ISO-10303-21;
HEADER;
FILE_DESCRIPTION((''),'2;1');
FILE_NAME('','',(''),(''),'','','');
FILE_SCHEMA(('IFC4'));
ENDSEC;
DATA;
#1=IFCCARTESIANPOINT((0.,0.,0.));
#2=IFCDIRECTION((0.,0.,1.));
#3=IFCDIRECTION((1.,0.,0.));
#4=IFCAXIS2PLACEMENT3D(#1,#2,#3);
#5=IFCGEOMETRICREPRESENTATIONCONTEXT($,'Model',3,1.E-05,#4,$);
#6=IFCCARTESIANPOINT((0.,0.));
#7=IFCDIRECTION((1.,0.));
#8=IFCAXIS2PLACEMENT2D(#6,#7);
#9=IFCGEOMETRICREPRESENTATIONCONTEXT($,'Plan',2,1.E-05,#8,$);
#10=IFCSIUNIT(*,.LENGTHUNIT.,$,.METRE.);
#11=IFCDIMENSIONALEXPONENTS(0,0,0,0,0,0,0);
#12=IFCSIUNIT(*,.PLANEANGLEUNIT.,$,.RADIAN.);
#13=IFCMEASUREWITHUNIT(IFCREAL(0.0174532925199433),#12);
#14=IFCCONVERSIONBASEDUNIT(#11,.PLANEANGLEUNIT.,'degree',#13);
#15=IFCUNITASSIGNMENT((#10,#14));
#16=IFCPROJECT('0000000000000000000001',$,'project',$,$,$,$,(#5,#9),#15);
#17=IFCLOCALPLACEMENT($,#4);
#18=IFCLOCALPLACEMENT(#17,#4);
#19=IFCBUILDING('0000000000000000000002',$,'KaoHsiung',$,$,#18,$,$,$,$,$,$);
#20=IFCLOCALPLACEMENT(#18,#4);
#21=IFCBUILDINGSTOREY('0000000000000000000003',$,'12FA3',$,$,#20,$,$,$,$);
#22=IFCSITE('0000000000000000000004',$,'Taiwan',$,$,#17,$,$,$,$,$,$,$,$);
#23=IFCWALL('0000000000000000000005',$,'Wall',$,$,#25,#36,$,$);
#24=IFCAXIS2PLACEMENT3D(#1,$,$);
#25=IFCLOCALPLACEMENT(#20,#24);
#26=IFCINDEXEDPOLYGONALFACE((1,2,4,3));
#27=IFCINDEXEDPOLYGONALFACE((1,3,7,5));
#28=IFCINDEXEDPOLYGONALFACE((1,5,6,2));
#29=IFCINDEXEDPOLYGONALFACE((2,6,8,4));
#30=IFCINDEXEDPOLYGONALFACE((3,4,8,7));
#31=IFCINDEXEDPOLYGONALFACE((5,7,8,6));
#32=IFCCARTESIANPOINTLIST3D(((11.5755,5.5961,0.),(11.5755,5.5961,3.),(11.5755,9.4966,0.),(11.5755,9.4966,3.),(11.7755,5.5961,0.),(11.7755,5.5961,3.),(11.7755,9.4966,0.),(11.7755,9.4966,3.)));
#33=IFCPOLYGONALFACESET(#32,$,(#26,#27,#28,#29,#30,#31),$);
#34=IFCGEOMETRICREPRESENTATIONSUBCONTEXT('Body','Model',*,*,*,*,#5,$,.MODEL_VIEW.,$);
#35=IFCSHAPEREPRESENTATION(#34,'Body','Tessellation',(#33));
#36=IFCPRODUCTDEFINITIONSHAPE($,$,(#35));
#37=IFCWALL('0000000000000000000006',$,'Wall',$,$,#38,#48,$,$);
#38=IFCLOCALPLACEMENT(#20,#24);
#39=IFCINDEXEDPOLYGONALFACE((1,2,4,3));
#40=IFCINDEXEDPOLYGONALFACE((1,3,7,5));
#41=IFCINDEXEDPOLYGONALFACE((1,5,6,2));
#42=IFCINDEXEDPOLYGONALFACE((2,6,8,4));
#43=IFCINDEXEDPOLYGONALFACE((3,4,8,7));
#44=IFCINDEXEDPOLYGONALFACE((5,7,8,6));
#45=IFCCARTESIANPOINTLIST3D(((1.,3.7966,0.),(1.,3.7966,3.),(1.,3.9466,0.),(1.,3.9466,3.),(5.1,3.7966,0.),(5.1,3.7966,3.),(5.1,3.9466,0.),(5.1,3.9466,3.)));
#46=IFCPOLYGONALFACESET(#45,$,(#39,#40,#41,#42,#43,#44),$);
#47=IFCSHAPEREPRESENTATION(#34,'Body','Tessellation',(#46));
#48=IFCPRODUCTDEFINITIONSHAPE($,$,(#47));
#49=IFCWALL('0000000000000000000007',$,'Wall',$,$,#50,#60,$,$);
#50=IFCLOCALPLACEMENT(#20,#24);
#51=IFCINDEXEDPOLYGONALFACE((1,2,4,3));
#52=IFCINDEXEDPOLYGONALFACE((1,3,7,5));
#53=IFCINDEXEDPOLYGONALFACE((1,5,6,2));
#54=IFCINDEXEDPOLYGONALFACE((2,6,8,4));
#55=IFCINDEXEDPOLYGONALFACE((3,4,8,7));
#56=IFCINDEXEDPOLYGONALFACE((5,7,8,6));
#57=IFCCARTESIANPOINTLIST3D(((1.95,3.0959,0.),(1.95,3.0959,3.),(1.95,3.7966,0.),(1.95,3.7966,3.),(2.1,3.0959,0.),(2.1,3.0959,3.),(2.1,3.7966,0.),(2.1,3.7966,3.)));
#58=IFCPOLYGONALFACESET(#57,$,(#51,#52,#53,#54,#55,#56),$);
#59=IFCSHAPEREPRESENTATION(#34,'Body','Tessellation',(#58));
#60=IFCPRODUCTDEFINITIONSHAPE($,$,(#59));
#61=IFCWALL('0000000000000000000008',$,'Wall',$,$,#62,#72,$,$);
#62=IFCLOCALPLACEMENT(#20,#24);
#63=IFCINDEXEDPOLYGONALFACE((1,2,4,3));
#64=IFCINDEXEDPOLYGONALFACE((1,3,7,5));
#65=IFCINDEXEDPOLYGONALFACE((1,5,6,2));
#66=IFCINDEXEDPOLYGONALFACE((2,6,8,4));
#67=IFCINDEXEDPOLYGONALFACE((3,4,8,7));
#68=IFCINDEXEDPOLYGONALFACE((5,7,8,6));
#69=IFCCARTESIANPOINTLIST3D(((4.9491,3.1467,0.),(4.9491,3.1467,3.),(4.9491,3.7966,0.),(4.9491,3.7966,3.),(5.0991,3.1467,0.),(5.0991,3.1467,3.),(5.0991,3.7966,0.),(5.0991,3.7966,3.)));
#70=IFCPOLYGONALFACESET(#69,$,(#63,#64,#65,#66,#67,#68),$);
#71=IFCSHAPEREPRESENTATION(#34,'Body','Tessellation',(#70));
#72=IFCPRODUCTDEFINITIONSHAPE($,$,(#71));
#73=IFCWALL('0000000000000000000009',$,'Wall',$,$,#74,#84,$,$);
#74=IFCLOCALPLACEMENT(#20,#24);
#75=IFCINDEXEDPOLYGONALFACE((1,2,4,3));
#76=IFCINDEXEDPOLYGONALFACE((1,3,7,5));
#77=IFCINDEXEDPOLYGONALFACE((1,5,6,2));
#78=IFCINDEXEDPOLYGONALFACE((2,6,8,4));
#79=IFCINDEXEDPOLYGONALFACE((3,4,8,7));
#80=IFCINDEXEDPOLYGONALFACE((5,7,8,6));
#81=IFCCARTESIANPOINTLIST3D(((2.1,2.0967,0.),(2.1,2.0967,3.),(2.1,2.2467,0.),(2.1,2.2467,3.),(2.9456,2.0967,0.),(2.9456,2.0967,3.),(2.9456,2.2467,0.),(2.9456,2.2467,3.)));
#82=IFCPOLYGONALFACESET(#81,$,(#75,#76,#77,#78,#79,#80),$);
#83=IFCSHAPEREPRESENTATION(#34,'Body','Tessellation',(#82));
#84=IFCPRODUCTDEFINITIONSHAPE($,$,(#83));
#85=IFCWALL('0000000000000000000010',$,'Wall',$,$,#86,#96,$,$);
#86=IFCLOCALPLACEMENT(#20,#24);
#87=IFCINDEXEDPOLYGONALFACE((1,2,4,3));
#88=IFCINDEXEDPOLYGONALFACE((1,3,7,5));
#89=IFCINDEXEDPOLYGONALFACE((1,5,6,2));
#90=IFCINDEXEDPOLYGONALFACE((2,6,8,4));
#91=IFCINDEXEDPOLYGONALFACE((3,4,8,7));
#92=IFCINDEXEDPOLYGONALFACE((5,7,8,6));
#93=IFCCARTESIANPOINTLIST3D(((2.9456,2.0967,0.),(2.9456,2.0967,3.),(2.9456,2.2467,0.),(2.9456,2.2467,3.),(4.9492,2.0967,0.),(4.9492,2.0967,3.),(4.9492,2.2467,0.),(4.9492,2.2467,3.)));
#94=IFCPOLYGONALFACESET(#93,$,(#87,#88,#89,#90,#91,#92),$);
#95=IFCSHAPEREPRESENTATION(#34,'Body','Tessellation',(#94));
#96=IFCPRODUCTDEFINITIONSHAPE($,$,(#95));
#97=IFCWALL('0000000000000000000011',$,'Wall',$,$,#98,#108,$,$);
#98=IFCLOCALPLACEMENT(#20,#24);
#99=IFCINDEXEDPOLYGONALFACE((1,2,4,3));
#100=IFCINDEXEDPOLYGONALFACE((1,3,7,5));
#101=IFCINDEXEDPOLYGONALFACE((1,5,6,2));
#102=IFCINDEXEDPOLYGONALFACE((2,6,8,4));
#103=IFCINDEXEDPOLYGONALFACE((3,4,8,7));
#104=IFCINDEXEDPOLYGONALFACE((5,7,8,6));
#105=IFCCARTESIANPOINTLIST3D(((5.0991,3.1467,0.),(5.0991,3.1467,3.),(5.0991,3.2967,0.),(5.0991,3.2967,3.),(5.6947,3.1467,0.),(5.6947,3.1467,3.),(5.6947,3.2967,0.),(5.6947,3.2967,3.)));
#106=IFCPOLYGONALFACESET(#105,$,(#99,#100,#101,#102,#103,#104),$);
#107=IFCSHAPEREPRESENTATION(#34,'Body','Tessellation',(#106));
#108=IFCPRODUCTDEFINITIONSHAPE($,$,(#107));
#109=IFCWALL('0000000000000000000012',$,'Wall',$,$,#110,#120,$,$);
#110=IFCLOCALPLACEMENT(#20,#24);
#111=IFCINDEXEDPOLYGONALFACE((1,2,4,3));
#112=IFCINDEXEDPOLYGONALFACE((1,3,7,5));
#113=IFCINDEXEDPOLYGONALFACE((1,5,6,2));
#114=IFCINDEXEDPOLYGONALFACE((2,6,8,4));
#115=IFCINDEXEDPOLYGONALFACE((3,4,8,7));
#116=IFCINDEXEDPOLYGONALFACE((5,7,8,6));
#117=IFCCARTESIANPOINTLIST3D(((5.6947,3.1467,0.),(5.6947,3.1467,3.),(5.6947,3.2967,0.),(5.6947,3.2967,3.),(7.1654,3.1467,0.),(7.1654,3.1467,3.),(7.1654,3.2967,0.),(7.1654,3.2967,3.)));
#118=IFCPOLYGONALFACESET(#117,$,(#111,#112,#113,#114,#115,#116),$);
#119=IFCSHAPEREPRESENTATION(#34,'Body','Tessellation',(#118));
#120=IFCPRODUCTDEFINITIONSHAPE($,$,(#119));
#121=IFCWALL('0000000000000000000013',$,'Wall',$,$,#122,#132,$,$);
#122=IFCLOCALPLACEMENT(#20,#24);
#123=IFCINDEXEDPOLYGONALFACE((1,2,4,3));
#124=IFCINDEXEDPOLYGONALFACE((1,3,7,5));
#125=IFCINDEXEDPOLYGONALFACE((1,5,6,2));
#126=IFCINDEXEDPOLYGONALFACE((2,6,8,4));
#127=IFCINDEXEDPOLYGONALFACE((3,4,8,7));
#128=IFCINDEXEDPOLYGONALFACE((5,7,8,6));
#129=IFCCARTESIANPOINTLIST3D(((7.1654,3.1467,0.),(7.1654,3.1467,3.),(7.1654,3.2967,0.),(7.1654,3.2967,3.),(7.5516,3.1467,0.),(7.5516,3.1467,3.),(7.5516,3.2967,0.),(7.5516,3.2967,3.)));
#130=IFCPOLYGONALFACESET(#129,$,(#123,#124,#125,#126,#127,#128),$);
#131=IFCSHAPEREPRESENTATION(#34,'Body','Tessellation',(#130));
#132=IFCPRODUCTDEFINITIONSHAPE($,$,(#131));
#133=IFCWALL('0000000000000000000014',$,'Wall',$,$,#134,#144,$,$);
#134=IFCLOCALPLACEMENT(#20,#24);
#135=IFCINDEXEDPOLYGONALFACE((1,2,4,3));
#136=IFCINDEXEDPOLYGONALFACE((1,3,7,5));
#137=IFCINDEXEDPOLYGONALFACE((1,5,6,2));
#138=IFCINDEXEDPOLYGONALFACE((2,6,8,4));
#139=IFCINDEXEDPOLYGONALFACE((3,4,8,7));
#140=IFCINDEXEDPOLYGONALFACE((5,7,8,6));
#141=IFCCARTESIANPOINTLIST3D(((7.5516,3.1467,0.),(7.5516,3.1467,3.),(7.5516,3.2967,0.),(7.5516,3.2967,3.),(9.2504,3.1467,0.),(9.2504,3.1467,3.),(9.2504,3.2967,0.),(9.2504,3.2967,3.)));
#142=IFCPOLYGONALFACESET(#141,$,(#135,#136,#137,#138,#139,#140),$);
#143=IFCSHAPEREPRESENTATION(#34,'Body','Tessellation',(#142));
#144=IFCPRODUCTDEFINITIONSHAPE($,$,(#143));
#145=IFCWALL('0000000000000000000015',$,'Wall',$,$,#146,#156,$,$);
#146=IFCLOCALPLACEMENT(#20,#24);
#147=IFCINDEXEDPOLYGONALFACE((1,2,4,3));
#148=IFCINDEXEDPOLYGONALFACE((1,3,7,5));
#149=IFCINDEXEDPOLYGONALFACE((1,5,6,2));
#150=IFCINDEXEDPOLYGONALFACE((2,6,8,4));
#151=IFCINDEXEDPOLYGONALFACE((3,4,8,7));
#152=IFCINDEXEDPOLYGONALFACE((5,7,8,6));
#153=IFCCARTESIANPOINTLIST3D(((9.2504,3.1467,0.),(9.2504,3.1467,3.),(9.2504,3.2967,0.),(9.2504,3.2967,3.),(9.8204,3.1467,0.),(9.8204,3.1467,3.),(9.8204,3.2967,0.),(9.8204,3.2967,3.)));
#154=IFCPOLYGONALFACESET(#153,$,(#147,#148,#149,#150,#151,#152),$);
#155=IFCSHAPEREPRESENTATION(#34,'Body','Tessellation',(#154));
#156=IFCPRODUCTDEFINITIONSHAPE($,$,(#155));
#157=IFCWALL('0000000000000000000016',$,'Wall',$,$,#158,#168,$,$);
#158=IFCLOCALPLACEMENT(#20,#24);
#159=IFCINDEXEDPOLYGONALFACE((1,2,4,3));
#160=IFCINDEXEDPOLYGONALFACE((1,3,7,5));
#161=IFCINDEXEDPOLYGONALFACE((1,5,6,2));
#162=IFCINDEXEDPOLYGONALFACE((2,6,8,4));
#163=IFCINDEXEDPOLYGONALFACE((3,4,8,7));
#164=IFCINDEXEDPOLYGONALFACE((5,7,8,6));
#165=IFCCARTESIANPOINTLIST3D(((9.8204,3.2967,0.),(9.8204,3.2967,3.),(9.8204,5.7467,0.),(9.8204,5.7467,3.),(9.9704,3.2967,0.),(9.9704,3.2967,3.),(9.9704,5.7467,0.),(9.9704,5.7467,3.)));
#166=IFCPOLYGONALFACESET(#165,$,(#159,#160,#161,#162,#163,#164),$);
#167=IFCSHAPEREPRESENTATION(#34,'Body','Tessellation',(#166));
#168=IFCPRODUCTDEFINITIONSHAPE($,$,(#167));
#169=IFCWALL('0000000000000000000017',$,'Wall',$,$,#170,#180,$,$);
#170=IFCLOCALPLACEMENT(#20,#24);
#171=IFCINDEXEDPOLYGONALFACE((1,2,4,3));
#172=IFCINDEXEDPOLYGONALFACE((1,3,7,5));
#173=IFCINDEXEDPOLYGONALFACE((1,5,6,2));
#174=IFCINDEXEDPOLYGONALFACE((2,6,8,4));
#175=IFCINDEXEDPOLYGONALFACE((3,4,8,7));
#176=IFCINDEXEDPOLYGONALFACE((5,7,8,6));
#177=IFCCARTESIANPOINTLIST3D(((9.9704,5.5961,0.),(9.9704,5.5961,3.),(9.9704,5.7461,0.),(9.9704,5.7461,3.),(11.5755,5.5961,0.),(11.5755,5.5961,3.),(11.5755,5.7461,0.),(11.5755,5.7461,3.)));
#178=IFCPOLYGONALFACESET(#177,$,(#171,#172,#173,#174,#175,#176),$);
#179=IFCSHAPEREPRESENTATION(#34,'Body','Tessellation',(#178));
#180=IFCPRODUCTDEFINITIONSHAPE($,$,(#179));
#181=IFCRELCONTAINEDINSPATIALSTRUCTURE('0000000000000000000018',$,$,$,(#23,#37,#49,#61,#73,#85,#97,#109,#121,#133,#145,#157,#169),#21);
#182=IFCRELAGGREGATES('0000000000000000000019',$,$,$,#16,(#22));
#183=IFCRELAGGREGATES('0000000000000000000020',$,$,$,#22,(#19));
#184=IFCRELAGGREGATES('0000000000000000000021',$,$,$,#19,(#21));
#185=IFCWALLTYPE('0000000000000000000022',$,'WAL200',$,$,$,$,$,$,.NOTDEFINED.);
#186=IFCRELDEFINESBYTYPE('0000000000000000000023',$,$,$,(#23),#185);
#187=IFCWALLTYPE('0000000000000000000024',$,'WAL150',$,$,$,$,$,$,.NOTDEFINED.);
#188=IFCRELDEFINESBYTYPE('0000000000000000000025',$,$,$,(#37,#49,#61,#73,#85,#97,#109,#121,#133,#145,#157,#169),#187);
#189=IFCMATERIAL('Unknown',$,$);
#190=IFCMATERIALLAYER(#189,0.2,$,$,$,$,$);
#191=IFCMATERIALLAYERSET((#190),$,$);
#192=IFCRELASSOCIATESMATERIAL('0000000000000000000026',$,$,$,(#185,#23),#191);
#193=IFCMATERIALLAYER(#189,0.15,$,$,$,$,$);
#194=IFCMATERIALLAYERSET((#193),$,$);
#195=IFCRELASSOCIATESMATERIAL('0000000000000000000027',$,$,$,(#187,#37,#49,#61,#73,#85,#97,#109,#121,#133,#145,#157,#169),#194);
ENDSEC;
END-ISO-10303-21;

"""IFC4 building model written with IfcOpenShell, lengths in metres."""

from ifc_helpers import new_model, entity, si_unit, converted_unit, frame, origin_with_axes, origin_2d_with_axis, place, context, subcontext, project, spatial, line, indexed_curve, outline, extrude, material, layer, layer_set, layer_usage, type_object, element, save


model = new_model("IFC4")

# Units and contexts
model_context = context("Model", 3, precision=1e-05, world=origin_with_axes())
plan_context = context("Plan", 2, precision=1e-05, world=origin_2d_with_axis())
body_context = subcontext(model_context, "Body", "Model", "MODEL_VIEW")
ifc_project = project(units=[si_unit("LENGTHUNIT", "METRE"), converted_unit("PLANEANGLEUNIT", "degree", entity("IfcReal", 0.0174532925199433), si_unit("PLANEANGLEUNIT", "RADIAN"), dimensions=[0, 0, 0, 0, 0, 0, 0])], contexts=[model_context, plan_context])

# Site, building, storey
site_placement = place(None, origin_with_axes())
site = spatial("IfcSite", under=ifc_project, at=site_placement, Name="Taiwan")
building_placement = place(site_placement, origin_with_axes())
building = spatial("IfcBuilding", under=site, at=building_placement, Name="KaoHsiung")
storey_placement = place(building_placement, origin_with_axes())
storey = spatial("IfcBuildingStorey", under=building, at=storey_placement, Name="12FA3")

# Shared definitions
ifc_material = material(Name="Unknown")

# Walls
ifc_layer_1 = layer(ifc_material, 0.2)
ifc_layer_set_1 = layer_set([ifc_layer_1])
ifc_layer_usage_1 = layer_usage(ifc_layer_set_1, "AXIS2", "POSITIVE", 0.0)
wall_type_1 = type_object("IfcWallType", Name="WAL200", PredefinedType="NOTDEFINED", material=ifc_layer_set_1)
wall_1_placement = place(storey_placement, frame((11.7755, 5.5961, 0.0), z_axis=(0.0, 0.0, 1.0), x_axis=(0.0, 1.0, 0.0)))
element("IfcWall", 1, at=wall_1_placement, inside=storey, type_object=wall_type_1, material=ifc_layer_usage_1, Name="Wall", context=body_context, shape_type="SweptSolid", body=[
    extrude(outline(indexed_curve([(0.0, 0.0), (0.0, 0.2), (3.9005, 0.2), (3.9005, 0.0)], segments=[line(1, 2, 3, 4, 1)])), origin_with_axes(), (0.0, 0.0, 1.0), 3.0),
])
ifc_layer_2 = layer(ifc_material, 0.15)
ifc_layer_set_2 = layer_set([ifc_layer_2])
ifc_layer_usage_2 = layer_usage(ifc_layer_set_2, "AXIS2", "POSITIVE", 0.0)
wall_type_2 = type_object("IfcWallType", Name="WAL150", PredefinedType="NOTDEFINED", material=ifc_layer_set_2)
wall_2_placement = place(storey_placement, frame((1.0, 3.7966, 0.0), z_axis=(0.0, 0.0, 1.0), x_axis=(1.0, 0.0, 0.0)))
element("IfcWall", 2, at=wall_2_placement, inside=storey, type_object=wall_type_2, material=ifc_layer_usage_2, Name="Wall", context=body_context, shape_type="SweptSolid", body=[
    extrude(outline(indexed_curve([(0.0, 0.0), (0.0, 0.15), (4.1, 0.15), (4.1, 0.0)], segments=[line(1, 2, 3, 4, 1)])), origin_with_axes(), (0.0, 0.0, 1.0), 3.0),
])
ifc_layer_usage_3 = layer_usage(ifc_layer_set_2, "AXIS2", "POSITIVE", 0.0)
wall_3_placement = place(storey_placement, frame((1.95, 3.7966, 0.0), z_axis=(0.0, 0.0, 1.0), x_axis=(0.0, -1.0, 0.0)))
element("IfcWall", 3, at=wall_3_placement, inside=storey, type_object=wall_type_2, material=ifc_layer_usage_3, Name="Wall", context=body_context, shape_type="SweptSolid", body=[
    extrude(outline(indexed_curve([(0.0, 0.0), (0.0, 0.15), (0.7007, 0.15), (0.7007, 0.0)], segments=[line(1, 2, 3, 4, 1)])), origin_with_axes(), (0.0, 0.0, 1.0), 3.0),
])
ifc_layer_usage_4 = layer_usage(ifc_layer_set_2, "AXIS2", "POSITIVE", 0.0)
wall_4_placement = place(storey_placement, frame((4.9491, 3.7966, 0.0), z_axis=(0.0, 0.0, 1.0), x_axis=(0.0, -1.0, 0.0)))
element("IfcWall", 4, at=wall_4_placement, inside=storey, type_object=wall_type_2, material=ifc_layer_usage_4, Name="Wall", context=body_context, shape_type="SweptSolid", body=[
    extrude(outline(indexed_curve([(0.0, 0.0), (0.0, 0.15), (0.6499, 0.15), (0.6499, 0.0)], segments=[line(1, 2, 3, 4, 1)])), origin_with_axes(), (0.0, 0.0, 1.0), 3.0),
])
ifc_layer_usage_5 = layer_usage(ifc_layer_set_2, "AXIS2", "POSITIVE", 0.0)
wall_5_placement = place(storey_placement, frame((2.1, 2.0967, 0.0), z_axis=(0.0, 0.0, 1.0), x_axis=(1.0, 0.0, 0.0)))
element("IfcWall", 5, at=wall_5_placement, inside=storey, type_object=wall_type_2, material=ifc_layer_usage_5, Name="Wall", context=body_context, shape_type="SweptSolid", body=[
    extrude(outline(indexed_curve([(0.0, 0.0), (0.0, 0.15), (0.8456, 0.15), (0.8456, 0.0)], segments=[line(1, 2, 3, 4, 1)])), origin_with_axes(), (0.0, 0.0, 1.0), 3.0),
])
ifc_layer_usage_6 = layer_usage(ifc_layer_set_2, "AXIS2", "POSITIVE", 0.0)
wall_6_placement = place(storey_placement, frame((2.9456, 2.0967, 0.0), z_axis=(0.0, 0.0, 1.0), x_axis=(1.0, 0.0, 0.0)))
element("IfcWall", 6, at=wall_6_placement, inside=storey, type_object=wall_type_2, material=ifc_layer_usage_6, Name="Wall", context=body_context, shape_type="SweptSolid", body=[
    extrude(outline(indexed_curve([(0.0, 0.0), (0.0, 0.15), (2.0037, 0.15), (2.0037, 0.0)], segments=[line(1, 2, 3, 4, 1)])), origin_with_axes(), (0.0, 0.0, 1.0), 3.0),
])
ifc_layer_usage_7 = layer_usage(ifc_layer_set_2, "AXIS2", "POSITIVE", 0.0)
wall_7_placement = place(storey_placement, frame((5.0991, 3.1467, 0.0), z_axis=(0.0, 0.0, 1.0), x_axis=(1.0, 0.0, 0.0)))
element("IfcWall", 7, at=wall_7_placement, inside=storey, type_object=wall_type_2, material=ifc_layer_usage_7, Name="Wall", context=body_context, shape_type="SweptSolid", body=[
    extrude(outline(indexed_curve([(0.0, 0.0), (0.0, 0.15), (0.5956, 0.15), (0.5956, 0.0)], segments=[line(1, 2, 3, 4, 1)])), origin_with_axes(), (0.0, 0.0, 1.0), 3.0),
])
ifc_layer_usage_8 = layer_usage(ifc_layer_set_2, "AXIS2", "POSITIVE", 0.0)
wall_8_placement = place(storey_placement, frame((5.6947, 3.1467, 0.0), z_axis=(0.0, 0.0, 1.0), x_axis=(1.0, 0.0, 0.0)))
element("IfcWall", 8, at=wall_8_placement, inside=storey, type_object=wall_type_2, material=ifc_layer_usage_8, Name="Wall", context=body_context, shape_type="SweptSolid", body=[
    extrude(outline(indexed_curve([(0.0, 0.0), (0.0, 0.15), (1.4706, 0.15), (1.4706, 0.0)], segments=[line(1, 2, 3, 4, 1)])), origin_with_axes(), (0.0, 0.0, 1.0), 3.0),
])
ifc_layer_usage_9 = layer_usage(ifc_layer_set_2, "AXIS2", "POSITIVE", 0.0)
wall_9_placement = place(storey_placement, frame((7.1654, 3.1467, 0.0), z_axis=(0.0, 0.0, 1.0), x_axis=(1.0, 0.0, 0.0)))
element("IfcWall", 9, at=wall_9_placement, inside=storey, type_object=wall_type_2, material=ifc_layer_usage_9, Name="Wall", context=body_context, shape_type="SweptSolid", body=[
    extrude(outline(indexed_curve([(0.0, 0.0), (0.0, 0.15), (0.3862, 0.15), (0.3862, 0.0)], segments=[line(1, 2, 3, 4, 1)])), origin_with_axes(), (0.0, 0.0, 1.0), 3.0),
])
ifc_layer_usage_10 = layer_usage(ifc_layer_set_2, "AXIS2", "POSITIVE", 0.0)
wall_10_placement = place(storey_placement, frame((7.5516, 3.1467, 0.0), z_axis=(0.0, 0.0, 1.0), x_axis=(1.0, 0.0, 0.0)))
element("IfcWall", 10, at=wall_10_placement, inside=storey, type_object=wall_type_2, material=ifc_layer_usage_10, Name="Wall", context=body_context, shape_type="SweptSolid", body=[
    extrude(outline(indexed_curve([(0.0, 0.0), (0.0, 0.15), (1.6987, 0.15), (1.6987, 0.0)], segments=[line(1, 2, 3, 4, 1)])), origin_with_axes(), (0.0, 0.0, 1.0), 3.0),
])
ifc_layer_usage_11 = layer_usage(ifc_layer_set_2, "AXIS2", "POSITIVE", 0.0)
wall_11_placement = place(storey_placement, frame((9.2504, 3.1467, 0.0), z_axis=(0.0, 0.0, 1.0), x_axis=(1.0, 0.0, 0.0)))
element("IfcWall", 11, at=wall_11_placement, inside=storey, type_object=wall_type_2, material=ifc_layer_usage_11, Name="Wall", context=body_context, shape_type="SweptSolid", body=[
    extrude(outline(indexed_curve([(0.0, 0.0), (0.0, 0.15), (0.57, 0.15), (0.57, 0.0)], segments=[line(1, 2, 3, 4, 1)])), origin_with_axes(), (0.0, 0.0, 1.0), 3.0),
])
ifc_layer_usage_12 = layer_usage(ifc_layer_set_2, "AXIS2", "POSITIVE", 0.0)
wall_12_placement = place(storey_placement, frame((9.9704, 3.2967, 0.0), z_axis=(0.0, 0.0, 1.0), x_axis=(0.0, 1.0, 0.0)))
element("IfcWall", 12, at=wall_12_placement, inside=storey, type_object=wall_type_2, material=ifc_layer_usage_12, Name="Wall", context=body_context, shape_type="SweptSolid", body=[
    extrude(outline(indexed_curve([(0.0, 0.0), (0.0, 0.15), (2.45, 0.15), (2.45, 0.0)], segments=[line(1, 2, 3, 4, 1)])), origin_with_axes(), (0.0, 0.0, 1.0), 3.0),
])
ifc_layer_usage_13 = layer_usage(ifc_layer_set_2, "AXIS2", "POSITIVE", 0.0)
wall_13_placement = place(storey_placement, frame((9.9704, 5.5961, 0.0), z_axis=(0.0, 0.0, 1.0), x_axis=(1.0, 0.0, 0.0)))
element("IfcWall", 13, at=wall_13_placement, inside=storey, type_object=wall_type_2, material=ifc_layer_usage_13, Name="Wall", context=body_context, shape_type="SweptSolid", body=[
    extrude(outline(indexed_curve([(0.0, 0.0), (0.0, 0.15), (1.6051, 0.15), (1.6051, 0.0)], segments=[line(1, 2, 3, 4, 1)])), origin_with_axes(), (0.0, 0.0, 1.0), 3.0),
])

save(model, "model.ifc")
